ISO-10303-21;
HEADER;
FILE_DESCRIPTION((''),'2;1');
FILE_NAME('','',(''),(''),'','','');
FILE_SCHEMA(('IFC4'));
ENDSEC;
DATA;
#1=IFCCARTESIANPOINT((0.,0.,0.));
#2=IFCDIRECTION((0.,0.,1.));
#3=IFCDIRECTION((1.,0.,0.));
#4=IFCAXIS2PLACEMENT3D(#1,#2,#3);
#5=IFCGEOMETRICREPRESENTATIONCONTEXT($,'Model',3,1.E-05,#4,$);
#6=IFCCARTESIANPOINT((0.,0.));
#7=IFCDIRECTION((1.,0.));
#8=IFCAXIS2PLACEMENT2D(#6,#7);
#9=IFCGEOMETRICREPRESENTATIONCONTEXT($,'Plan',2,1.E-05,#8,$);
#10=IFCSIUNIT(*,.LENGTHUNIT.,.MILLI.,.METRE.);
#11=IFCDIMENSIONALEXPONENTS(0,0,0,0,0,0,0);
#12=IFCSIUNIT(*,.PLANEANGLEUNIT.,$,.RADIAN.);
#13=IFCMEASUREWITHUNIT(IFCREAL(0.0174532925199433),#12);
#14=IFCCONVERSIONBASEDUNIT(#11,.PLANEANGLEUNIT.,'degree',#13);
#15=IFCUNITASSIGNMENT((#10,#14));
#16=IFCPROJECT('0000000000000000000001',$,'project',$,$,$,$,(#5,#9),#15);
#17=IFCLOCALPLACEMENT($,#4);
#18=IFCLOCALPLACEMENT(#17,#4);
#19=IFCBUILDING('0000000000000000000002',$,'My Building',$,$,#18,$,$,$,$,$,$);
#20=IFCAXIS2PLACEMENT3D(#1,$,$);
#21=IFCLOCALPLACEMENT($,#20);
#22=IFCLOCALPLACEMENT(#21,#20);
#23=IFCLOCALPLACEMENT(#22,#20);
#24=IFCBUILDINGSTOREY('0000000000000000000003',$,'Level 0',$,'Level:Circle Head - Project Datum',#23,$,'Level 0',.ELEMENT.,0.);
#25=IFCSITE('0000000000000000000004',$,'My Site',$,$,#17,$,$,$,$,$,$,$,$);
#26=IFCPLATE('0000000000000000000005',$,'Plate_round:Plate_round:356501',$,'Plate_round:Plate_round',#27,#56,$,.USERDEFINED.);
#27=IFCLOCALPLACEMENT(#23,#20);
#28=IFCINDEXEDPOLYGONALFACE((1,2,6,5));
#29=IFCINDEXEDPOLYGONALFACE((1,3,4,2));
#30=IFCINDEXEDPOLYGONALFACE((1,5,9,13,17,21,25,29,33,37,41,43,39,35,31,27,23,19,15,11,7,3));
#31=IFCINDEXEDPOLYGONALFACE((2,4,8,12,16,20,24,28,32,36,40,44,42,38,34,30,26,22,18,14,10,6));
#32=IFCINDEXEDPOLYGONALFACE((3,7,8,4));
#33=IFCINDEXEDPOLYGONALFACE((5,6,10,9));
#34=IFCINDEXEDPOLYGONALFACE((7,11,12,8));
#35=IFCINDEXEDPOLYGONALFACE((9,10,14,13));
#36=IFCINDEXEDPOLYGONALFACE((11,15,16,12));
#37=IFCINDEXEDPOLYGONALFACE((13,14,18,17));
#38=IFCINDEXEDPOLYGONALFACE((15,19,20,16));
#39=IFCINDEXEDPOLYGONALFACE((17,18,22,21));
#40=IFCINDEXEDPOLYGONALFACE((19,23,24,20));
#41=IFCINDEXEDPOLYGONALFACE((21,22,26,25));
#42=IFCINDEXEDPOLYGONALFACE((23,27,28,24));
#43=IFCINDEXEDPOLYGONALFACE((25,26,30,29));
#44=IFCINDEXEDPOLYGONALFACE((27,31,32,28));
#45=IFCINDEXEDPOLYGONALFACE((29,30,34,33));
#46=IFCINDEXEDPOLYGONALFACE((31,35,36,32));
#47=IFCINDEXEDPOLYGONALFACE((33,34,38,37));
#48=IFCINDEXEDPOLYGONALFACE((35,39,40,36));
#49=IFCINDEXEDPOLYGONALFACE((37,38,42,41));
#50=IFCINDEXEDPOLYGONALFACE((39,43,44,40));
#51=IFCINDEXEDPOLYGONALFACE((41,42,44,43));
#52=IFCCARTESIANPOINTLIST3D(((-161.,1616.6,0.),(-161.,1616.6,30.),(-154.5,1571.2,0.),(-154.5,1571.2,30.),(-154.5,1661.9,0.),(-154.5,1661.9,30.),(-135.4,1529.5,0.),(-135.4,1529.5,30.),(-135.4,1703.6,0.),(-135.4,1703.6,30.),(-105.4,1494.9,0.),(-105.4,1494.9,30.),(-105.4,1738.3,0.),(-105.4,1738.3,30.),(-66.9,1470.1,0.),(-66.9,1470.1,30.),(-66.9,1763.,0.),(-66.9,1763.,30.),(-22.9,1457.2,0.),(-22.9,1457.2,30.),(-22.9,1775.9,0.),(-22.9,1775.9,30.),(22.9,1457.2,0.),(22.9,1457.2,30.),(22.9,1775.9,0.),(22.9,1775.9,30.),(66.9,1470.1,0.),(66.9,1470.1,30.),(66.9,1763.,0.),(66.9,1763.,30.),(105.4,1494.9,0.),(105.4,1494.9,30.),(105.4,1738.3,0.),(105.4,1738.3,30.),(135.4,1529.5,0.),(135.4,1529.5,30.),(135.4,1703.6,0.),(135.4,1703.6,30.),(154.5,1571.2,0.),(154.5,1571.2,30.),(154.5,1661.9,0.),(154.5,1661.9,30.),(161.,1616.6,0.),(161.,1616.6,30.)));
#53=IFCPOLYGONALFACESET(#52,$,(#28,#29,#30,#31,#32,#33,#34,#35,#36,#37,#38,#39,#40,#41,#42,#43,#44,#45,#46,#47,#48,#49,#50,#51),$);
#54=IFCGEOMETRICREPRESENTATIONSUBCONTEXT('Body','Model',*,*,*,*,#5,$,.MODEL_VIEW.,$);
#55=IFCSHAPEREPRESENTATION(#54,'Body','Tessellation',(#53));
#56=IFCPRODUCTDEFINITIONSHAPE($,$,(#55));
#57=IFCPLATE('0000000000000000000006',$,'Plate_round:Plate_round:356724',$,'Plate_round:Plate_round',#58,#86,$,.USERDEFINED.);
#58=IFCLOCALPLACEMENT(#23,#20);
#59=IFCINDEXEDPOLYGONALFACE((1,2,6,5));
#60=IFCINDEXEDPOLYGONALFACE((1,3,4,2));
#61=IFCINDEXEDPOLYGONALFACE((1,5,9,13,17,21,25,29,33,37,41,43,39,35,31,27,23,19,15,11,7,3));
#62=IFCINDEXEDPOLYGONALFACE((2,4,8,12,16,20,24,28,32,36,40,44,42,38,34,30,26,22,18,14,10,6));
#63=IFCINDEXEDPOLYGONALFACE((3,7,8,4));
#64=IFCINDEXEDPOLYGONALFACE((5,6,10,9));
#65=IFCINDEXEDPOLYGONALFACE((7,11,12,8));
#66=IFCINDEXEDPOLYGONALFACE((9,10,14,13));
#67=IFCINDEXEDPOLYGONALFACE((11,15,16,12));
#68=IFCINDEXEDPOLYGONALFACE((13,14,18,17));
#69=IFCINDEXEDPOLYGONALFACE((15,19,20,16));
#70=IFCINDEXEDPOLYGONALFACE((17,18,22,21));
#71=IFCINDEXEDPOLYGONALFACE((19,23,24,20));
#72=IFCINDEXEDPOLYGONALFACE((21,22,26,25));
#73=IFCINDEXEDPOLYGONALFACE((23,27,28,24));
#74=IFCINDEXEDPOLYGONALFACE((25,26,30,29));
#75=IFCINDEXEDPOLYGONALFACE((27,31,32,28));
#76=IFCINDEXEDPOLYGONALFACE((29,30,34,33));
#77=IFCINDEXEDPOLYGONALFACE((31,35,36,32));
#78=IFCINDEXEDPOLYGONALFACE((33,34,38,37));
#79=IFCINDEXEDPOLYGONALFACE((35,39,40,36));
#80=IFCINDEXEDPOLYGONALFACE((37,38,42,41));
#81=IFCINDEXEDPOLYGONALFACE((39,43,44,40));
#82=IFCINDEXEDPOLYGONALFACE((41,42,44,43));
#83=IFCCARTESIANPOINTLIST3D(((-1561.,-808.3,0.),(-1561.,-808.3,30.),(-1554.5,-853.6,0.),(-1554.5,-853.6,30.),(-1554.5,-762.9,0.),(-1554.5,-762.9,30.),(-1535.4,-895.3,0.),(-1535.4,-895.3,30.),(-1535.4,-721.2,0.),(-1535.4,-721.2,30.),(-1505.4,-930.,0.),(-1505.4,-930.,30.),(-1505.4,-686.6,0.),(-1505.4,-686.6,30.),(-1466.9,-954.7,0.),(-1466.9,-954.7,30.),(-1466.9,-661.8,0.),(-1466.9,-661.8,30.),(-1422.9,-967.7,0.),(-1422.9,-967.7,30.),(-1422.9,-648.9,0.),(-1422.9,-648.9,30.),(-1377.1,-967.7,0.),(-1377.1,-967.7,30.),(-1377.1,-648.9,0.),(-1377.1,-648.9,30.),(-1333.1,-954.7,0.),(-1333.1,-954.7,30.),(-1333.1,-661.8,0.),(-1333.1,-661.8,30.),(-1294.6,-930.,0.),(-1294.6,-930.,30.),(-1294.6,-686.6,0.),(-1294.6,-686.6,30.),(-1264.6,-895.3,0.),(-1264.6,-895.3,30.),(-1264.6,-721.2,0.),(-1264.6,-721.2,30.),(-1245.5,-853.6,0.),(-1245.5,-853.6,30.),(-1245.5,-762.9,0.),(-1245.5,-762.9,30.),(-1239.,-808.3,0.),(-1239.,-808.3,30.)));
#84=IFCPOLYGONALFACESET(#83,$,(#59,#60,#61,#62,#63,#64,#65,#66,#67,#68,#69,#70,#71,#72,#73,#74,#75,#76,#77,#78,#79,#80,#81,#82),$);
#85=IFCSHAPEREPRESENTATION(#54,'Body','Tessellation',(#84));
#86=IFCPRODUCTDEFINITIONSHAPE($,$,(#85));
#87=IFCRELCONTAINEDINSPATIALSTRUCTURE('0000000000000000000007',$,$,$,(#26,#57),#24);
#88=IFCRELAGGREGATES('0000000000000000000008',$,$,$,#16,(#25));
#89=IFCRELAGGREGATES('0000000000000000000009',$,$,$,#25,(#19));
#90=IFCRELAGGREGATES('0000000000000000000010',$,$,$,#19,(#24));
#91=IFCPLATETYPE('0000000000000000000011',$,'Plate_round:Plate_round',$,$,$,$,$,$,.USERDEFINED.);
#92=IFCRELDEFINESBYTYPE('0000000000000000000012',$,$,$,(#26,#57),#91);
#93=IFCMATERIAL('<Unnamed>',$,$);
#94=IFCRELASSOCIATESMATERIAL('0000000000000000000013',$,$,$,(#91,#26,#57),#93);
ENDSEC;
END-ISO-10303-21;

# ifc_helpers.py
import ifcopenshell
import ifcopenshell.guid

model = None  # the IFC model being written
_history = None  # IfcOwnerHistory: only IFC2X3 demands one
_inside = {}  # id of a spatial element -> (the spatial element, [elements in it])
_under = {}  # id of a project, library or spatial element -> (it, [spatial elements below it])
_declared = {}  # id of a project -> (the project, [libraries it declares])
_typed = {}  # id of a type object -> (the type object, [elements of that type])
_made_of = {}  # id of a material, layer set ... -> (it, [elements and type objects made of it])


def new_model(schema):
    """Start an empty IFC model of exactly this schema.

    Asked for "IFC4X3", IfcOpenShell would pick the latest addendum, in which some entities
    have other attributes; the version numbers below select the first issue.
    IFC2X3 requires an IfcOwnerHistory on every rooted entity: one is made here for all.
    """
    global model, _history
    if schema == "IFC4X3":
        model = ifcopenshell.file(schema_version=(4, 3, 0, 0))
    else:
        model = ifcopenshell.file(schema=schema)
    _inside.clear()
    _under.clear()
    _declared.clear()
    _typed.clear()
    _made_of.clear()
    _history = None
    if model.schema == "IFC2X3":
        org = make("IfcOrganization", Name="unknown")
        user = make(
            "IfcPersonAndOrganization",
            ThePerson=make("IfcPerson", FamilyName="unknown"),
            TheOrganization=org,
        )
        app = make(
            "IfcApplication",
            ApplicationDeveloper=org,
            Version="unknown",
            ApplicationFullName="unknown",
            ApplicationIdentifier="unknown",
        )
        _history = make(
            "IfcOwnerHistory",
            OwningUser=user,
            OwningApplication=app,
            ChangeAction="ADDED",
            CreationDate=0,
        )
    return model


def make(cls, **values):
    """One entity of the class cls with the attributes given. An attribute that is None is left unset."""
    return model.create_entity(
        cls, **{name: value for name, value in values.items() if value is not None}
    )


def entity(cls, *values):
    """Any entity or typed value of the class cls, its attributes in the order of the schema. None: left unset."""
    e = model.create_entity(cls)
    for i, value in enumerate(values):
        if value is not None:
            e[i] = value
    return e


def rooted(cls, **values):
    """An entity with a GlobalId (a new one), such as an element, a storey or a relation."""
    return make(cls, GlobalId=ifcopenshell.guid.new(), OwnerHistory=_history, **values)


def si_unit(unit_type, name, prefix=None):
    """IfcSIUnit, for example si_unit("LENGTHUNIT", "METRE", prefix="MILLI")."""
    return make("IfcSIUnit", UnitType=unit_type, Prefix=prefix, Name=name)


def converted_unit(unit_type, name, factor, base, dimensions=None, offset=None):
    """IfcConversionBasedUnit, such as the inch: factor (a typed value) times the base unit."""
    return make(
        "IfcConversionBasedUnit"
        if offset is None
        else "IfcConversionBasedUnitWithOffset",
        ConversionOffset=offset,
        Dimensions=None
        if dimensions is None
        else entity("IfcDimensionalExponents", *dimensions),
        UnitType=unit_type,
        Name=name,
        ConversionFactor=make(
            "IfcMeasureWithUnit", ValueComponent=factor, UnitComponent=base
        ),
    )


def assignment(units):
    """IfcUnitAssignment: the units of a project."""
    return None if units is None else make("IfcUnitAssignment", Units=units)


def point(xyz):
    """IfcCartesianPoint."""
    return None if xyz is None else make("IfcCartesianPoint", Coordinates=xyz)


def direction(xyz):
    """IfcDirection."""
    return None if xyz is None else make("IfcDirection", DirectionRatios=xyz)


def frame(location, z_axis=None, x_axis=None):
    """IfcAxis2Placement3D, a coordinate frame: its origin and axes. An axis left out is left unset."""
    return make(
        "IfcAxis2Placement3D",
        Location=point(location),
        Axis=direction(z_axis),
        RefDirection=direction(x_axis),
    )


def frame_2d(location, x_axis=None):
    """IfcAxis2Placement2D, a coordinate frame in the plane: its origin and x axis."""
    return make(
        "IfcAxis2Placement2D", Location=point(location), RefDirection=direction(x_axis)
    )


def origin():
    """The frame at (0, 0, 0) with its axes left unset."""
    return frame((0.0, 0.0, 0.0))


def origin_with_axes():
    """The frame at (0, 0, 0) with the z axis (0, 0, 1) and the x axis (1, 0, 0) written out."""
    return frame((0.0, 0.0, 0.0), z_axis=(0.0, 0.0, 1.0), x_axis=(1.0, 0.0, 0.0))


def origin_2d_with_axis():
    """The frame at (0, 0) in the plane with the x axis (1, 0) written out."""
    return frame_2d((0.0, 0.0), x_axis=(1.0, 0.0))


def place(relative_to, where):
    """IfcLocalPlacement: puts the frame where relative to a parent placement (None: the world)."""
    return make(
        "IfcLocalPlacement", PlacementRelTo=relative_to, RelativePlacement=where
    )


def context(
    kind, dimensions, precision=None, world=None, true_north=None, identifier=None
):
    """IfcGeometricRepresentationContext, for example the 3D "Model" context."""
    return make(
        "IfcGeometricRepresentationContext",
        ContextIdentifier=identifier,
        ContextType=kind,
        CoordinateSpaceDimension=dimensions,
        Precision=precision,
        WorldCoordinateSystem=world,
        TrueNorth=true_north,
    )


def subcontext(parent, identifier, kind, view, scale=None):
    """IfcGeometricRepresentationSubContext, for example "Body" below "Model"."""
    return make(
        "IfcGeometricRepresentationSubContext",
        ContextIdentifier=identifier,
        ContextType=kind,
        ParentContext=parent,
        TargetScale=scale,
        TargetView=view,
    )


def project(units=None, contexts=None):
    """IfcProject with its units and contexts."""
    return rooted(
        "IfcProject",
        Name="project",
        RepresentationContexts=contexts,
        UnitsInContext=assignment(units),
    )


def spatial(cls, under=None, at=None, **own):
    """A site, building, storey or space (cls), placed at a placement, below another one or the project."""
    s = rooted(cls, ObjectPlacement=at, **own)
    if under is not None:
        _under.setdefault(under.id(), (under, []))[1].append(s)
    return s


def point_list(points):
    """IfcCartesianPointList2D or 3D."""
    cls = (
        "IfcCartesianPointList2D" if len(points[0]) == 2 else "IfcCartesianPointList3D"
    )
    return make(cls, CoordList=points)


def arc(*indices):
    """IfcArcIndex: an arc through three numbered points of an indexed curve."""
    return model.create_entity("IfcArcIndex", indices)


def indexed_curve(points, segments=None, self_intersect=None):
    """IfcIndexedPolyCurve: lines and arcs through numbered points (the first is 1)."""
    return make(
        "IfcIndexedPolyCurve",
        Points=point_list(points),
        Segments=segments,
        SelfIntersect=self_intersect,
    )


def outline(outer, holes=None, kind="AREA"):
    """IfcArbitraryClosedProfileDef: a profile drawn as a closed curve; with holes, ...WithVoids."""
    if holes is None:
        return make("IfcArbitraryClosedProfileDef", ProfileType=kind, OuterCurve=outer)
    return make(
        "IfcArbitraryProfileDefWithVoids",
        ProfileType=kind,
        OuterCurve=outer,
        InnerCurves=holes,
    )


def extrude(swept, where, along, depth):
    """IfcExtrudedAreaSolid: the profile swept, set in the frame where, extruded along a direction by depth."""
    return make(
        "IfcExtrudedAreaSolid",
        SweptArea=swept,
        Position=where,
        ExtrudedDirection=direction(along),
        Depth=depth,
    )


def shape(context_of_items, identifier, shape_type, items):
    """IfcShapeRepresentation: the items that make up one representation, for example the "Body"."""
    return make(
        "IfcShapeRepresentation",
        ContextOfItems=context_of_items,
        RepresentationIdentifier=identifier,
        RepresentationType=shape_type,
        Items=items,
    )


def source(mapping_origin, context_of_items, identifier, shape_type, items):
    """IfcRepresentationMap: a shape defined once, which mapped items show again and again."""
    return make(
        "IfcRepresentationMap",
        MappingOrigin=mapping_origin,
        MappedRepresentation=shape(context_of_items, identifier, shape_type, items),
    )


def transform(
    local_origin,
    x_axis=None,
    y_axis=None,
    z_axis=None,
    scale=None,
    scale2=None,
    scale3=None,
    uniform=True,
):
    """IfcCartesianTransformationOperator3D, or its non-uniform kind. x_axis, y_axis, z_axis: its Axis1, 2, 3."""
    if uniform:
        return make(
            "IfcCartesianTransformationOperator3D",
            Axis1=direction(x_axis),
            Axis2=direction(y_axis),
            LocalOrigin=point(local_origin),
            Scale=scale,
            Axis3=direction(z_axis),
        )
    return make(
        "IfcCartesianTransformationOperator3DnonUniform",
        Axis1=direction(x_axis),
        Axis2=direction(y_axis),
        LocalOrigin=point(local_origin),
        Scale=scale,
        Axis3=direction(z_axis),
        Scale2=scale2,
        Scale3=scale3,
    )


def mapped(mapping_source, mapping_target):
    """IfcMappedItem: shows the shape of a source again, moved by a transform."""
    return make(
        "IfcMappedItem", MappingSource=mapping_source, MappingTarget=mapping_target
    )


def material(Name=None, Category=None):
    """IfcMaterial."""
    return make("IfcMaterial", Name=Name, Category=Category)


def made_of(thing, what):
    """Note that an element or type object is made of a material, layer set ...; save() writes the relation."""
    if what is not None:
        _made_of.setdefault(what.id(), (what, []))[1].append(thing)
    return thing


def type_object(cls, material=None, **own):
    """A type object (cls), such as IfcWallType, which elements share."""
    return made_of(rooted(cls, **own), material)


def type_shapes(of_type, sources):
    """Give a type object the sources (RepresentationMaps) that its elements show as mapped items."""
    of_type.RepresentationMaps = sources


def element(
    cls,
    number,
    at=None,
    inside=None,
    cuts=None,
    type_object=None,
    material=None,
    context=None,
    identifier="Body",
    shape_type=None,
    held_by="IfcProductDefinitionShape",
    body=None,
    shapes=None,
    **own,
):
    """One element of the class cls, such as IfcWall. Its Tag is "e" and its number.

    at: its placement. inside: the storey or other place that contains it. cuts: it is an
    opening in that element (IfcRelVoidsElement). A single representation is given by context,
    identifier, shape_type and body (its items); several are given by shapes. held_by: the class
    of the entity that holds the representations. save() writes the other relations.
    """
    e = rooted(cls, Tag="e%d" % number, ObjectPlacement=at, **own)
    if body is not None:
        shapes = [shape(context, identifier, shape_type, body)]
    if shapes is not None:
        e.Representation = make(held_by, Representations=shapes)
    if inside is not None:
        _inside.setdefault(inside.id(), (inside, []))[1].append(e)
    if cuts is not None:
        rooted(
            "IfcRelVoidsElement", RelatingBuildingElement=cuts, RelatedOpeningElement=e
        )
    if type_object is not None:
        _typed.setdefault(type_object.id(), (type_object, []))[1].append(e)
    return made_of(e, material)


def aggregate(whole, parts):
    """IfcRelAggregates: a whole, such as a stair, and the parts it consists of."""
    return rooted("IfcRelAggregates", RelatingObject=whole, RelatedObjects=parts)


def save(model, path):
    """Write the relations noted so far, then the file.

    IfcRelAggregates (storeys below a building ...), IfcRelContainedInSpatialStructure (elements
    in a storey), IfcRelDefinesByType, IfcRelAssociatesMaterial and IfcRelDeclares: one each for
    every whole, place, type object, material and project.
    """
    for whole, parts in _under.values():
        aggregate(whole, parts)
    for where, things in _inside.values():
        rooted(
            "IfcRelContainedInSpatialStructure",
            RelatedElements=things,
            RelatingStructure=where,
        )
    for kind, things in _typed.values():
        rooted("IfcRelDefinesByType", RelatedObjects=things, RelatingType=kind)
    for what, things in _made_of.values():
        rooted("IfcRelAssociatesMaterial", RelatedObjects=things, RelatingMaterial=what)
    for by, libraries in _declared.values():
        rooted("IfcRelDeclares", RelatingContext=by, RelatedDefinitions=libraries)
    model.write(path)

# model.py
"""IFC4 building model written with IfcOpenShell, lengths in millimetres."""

from ifc_helpers import new_model, entity, si_unit, converted_unit, frame, origin, origin_with_axes, origin_2d_with_axis, place, context, subcontext, project, spatial, arc, indexed_curve, outline, extrude, source, transform, mapped, material, type_object, type_shapes, element, save


model = new_model("IFC4")

# Units and contexts
model_context = context("Model", 3, precision=1e-05, world=origin_with_axes())
plan_context = context("Plan", 2, precision=1e-05, world=origin_2d_with_axis())
body_context = subcontext(model_context, "Body", "Model", "MODEL_VIEW")
ifc_project = project(units=[si_unit("LENGTHUNIT", "METRE", prefix="MILLI"), converted_unit("PLANEANGLEUNIT", "degree", entity("IfcReal", 0.0174532925199433), si_unit("PLANEANGLEUNIT", "RADIAN"), dimensions=[0, 0, 0, 0, 0, 0, 0])], contexts=[model_context, plan_context])

# Site, building, storey
site_placement = place(None, origin_with_axes())
site = spatial("IfcSite", under=ifc_project, at=site_placement, Name="My Site")
building_placement = place(site_placement, origin_with_axes())
building = spatial("IfcBuilding", under=site, at=building_placement, Name="My Building")
placement_1 = place(None, origin())
placement_2 = place(placement_1, origin())
storey_placement = place(placement_2, origin())
storey = spatial("IfcBuildingStorey", under=building, at=storey_placement, Name="Level 0", ObjectType="Level:Circle Head - Project Datum", LongName="Level 0", CompositionType="ELEMENT", Elevation=0.0)

# Plates
ifc_material_1 = material(Name="<Unnamed>")
plate_type = type_object("IfcPlateType", Name="Plate_round:Plate_round", PredefinedType="USERDEFINED", material=ifc_material_1)
shared_shape_1 = source(origin(), body_context, "Body", "SweptSolid", [
    extrude(outline(indexed_curve([(-161.0, 0.0), (0.0, -161.0), (161.0, 0.0), (0.0, 161.0)], segments=[arc(1, 2, 3), arc(3, 4, 1)], self_intersect=False)), origin(), (0.0, 0.0, 1.0), 30.0),
])
type_shapes(plate_type, [shared_shape_1])
for number, where, name in (
    (1, (0.0, 1616.6, 0.0), "Plate_round:Plate_round:356501"),
    (2, (-1400.0, -808.3, 0.0), "Plate_round:Plate_round:356724"),
):
    element("IfcPlate", number, at=place(storey_placement, frame(where)), inside=storey, type_object=plate_type, material=ifc_material_1, Name=name, ObjectType="Plate_round:Plate_round", PredefinedType="USERDEFINED", context=body_context, shape_type="MappedRepresentation", body=[
        mapped(shared_shape_1, transform((0.0, 0.0, 0.0), scale=1.0)),
    ])

save(model, "model.ifc")
